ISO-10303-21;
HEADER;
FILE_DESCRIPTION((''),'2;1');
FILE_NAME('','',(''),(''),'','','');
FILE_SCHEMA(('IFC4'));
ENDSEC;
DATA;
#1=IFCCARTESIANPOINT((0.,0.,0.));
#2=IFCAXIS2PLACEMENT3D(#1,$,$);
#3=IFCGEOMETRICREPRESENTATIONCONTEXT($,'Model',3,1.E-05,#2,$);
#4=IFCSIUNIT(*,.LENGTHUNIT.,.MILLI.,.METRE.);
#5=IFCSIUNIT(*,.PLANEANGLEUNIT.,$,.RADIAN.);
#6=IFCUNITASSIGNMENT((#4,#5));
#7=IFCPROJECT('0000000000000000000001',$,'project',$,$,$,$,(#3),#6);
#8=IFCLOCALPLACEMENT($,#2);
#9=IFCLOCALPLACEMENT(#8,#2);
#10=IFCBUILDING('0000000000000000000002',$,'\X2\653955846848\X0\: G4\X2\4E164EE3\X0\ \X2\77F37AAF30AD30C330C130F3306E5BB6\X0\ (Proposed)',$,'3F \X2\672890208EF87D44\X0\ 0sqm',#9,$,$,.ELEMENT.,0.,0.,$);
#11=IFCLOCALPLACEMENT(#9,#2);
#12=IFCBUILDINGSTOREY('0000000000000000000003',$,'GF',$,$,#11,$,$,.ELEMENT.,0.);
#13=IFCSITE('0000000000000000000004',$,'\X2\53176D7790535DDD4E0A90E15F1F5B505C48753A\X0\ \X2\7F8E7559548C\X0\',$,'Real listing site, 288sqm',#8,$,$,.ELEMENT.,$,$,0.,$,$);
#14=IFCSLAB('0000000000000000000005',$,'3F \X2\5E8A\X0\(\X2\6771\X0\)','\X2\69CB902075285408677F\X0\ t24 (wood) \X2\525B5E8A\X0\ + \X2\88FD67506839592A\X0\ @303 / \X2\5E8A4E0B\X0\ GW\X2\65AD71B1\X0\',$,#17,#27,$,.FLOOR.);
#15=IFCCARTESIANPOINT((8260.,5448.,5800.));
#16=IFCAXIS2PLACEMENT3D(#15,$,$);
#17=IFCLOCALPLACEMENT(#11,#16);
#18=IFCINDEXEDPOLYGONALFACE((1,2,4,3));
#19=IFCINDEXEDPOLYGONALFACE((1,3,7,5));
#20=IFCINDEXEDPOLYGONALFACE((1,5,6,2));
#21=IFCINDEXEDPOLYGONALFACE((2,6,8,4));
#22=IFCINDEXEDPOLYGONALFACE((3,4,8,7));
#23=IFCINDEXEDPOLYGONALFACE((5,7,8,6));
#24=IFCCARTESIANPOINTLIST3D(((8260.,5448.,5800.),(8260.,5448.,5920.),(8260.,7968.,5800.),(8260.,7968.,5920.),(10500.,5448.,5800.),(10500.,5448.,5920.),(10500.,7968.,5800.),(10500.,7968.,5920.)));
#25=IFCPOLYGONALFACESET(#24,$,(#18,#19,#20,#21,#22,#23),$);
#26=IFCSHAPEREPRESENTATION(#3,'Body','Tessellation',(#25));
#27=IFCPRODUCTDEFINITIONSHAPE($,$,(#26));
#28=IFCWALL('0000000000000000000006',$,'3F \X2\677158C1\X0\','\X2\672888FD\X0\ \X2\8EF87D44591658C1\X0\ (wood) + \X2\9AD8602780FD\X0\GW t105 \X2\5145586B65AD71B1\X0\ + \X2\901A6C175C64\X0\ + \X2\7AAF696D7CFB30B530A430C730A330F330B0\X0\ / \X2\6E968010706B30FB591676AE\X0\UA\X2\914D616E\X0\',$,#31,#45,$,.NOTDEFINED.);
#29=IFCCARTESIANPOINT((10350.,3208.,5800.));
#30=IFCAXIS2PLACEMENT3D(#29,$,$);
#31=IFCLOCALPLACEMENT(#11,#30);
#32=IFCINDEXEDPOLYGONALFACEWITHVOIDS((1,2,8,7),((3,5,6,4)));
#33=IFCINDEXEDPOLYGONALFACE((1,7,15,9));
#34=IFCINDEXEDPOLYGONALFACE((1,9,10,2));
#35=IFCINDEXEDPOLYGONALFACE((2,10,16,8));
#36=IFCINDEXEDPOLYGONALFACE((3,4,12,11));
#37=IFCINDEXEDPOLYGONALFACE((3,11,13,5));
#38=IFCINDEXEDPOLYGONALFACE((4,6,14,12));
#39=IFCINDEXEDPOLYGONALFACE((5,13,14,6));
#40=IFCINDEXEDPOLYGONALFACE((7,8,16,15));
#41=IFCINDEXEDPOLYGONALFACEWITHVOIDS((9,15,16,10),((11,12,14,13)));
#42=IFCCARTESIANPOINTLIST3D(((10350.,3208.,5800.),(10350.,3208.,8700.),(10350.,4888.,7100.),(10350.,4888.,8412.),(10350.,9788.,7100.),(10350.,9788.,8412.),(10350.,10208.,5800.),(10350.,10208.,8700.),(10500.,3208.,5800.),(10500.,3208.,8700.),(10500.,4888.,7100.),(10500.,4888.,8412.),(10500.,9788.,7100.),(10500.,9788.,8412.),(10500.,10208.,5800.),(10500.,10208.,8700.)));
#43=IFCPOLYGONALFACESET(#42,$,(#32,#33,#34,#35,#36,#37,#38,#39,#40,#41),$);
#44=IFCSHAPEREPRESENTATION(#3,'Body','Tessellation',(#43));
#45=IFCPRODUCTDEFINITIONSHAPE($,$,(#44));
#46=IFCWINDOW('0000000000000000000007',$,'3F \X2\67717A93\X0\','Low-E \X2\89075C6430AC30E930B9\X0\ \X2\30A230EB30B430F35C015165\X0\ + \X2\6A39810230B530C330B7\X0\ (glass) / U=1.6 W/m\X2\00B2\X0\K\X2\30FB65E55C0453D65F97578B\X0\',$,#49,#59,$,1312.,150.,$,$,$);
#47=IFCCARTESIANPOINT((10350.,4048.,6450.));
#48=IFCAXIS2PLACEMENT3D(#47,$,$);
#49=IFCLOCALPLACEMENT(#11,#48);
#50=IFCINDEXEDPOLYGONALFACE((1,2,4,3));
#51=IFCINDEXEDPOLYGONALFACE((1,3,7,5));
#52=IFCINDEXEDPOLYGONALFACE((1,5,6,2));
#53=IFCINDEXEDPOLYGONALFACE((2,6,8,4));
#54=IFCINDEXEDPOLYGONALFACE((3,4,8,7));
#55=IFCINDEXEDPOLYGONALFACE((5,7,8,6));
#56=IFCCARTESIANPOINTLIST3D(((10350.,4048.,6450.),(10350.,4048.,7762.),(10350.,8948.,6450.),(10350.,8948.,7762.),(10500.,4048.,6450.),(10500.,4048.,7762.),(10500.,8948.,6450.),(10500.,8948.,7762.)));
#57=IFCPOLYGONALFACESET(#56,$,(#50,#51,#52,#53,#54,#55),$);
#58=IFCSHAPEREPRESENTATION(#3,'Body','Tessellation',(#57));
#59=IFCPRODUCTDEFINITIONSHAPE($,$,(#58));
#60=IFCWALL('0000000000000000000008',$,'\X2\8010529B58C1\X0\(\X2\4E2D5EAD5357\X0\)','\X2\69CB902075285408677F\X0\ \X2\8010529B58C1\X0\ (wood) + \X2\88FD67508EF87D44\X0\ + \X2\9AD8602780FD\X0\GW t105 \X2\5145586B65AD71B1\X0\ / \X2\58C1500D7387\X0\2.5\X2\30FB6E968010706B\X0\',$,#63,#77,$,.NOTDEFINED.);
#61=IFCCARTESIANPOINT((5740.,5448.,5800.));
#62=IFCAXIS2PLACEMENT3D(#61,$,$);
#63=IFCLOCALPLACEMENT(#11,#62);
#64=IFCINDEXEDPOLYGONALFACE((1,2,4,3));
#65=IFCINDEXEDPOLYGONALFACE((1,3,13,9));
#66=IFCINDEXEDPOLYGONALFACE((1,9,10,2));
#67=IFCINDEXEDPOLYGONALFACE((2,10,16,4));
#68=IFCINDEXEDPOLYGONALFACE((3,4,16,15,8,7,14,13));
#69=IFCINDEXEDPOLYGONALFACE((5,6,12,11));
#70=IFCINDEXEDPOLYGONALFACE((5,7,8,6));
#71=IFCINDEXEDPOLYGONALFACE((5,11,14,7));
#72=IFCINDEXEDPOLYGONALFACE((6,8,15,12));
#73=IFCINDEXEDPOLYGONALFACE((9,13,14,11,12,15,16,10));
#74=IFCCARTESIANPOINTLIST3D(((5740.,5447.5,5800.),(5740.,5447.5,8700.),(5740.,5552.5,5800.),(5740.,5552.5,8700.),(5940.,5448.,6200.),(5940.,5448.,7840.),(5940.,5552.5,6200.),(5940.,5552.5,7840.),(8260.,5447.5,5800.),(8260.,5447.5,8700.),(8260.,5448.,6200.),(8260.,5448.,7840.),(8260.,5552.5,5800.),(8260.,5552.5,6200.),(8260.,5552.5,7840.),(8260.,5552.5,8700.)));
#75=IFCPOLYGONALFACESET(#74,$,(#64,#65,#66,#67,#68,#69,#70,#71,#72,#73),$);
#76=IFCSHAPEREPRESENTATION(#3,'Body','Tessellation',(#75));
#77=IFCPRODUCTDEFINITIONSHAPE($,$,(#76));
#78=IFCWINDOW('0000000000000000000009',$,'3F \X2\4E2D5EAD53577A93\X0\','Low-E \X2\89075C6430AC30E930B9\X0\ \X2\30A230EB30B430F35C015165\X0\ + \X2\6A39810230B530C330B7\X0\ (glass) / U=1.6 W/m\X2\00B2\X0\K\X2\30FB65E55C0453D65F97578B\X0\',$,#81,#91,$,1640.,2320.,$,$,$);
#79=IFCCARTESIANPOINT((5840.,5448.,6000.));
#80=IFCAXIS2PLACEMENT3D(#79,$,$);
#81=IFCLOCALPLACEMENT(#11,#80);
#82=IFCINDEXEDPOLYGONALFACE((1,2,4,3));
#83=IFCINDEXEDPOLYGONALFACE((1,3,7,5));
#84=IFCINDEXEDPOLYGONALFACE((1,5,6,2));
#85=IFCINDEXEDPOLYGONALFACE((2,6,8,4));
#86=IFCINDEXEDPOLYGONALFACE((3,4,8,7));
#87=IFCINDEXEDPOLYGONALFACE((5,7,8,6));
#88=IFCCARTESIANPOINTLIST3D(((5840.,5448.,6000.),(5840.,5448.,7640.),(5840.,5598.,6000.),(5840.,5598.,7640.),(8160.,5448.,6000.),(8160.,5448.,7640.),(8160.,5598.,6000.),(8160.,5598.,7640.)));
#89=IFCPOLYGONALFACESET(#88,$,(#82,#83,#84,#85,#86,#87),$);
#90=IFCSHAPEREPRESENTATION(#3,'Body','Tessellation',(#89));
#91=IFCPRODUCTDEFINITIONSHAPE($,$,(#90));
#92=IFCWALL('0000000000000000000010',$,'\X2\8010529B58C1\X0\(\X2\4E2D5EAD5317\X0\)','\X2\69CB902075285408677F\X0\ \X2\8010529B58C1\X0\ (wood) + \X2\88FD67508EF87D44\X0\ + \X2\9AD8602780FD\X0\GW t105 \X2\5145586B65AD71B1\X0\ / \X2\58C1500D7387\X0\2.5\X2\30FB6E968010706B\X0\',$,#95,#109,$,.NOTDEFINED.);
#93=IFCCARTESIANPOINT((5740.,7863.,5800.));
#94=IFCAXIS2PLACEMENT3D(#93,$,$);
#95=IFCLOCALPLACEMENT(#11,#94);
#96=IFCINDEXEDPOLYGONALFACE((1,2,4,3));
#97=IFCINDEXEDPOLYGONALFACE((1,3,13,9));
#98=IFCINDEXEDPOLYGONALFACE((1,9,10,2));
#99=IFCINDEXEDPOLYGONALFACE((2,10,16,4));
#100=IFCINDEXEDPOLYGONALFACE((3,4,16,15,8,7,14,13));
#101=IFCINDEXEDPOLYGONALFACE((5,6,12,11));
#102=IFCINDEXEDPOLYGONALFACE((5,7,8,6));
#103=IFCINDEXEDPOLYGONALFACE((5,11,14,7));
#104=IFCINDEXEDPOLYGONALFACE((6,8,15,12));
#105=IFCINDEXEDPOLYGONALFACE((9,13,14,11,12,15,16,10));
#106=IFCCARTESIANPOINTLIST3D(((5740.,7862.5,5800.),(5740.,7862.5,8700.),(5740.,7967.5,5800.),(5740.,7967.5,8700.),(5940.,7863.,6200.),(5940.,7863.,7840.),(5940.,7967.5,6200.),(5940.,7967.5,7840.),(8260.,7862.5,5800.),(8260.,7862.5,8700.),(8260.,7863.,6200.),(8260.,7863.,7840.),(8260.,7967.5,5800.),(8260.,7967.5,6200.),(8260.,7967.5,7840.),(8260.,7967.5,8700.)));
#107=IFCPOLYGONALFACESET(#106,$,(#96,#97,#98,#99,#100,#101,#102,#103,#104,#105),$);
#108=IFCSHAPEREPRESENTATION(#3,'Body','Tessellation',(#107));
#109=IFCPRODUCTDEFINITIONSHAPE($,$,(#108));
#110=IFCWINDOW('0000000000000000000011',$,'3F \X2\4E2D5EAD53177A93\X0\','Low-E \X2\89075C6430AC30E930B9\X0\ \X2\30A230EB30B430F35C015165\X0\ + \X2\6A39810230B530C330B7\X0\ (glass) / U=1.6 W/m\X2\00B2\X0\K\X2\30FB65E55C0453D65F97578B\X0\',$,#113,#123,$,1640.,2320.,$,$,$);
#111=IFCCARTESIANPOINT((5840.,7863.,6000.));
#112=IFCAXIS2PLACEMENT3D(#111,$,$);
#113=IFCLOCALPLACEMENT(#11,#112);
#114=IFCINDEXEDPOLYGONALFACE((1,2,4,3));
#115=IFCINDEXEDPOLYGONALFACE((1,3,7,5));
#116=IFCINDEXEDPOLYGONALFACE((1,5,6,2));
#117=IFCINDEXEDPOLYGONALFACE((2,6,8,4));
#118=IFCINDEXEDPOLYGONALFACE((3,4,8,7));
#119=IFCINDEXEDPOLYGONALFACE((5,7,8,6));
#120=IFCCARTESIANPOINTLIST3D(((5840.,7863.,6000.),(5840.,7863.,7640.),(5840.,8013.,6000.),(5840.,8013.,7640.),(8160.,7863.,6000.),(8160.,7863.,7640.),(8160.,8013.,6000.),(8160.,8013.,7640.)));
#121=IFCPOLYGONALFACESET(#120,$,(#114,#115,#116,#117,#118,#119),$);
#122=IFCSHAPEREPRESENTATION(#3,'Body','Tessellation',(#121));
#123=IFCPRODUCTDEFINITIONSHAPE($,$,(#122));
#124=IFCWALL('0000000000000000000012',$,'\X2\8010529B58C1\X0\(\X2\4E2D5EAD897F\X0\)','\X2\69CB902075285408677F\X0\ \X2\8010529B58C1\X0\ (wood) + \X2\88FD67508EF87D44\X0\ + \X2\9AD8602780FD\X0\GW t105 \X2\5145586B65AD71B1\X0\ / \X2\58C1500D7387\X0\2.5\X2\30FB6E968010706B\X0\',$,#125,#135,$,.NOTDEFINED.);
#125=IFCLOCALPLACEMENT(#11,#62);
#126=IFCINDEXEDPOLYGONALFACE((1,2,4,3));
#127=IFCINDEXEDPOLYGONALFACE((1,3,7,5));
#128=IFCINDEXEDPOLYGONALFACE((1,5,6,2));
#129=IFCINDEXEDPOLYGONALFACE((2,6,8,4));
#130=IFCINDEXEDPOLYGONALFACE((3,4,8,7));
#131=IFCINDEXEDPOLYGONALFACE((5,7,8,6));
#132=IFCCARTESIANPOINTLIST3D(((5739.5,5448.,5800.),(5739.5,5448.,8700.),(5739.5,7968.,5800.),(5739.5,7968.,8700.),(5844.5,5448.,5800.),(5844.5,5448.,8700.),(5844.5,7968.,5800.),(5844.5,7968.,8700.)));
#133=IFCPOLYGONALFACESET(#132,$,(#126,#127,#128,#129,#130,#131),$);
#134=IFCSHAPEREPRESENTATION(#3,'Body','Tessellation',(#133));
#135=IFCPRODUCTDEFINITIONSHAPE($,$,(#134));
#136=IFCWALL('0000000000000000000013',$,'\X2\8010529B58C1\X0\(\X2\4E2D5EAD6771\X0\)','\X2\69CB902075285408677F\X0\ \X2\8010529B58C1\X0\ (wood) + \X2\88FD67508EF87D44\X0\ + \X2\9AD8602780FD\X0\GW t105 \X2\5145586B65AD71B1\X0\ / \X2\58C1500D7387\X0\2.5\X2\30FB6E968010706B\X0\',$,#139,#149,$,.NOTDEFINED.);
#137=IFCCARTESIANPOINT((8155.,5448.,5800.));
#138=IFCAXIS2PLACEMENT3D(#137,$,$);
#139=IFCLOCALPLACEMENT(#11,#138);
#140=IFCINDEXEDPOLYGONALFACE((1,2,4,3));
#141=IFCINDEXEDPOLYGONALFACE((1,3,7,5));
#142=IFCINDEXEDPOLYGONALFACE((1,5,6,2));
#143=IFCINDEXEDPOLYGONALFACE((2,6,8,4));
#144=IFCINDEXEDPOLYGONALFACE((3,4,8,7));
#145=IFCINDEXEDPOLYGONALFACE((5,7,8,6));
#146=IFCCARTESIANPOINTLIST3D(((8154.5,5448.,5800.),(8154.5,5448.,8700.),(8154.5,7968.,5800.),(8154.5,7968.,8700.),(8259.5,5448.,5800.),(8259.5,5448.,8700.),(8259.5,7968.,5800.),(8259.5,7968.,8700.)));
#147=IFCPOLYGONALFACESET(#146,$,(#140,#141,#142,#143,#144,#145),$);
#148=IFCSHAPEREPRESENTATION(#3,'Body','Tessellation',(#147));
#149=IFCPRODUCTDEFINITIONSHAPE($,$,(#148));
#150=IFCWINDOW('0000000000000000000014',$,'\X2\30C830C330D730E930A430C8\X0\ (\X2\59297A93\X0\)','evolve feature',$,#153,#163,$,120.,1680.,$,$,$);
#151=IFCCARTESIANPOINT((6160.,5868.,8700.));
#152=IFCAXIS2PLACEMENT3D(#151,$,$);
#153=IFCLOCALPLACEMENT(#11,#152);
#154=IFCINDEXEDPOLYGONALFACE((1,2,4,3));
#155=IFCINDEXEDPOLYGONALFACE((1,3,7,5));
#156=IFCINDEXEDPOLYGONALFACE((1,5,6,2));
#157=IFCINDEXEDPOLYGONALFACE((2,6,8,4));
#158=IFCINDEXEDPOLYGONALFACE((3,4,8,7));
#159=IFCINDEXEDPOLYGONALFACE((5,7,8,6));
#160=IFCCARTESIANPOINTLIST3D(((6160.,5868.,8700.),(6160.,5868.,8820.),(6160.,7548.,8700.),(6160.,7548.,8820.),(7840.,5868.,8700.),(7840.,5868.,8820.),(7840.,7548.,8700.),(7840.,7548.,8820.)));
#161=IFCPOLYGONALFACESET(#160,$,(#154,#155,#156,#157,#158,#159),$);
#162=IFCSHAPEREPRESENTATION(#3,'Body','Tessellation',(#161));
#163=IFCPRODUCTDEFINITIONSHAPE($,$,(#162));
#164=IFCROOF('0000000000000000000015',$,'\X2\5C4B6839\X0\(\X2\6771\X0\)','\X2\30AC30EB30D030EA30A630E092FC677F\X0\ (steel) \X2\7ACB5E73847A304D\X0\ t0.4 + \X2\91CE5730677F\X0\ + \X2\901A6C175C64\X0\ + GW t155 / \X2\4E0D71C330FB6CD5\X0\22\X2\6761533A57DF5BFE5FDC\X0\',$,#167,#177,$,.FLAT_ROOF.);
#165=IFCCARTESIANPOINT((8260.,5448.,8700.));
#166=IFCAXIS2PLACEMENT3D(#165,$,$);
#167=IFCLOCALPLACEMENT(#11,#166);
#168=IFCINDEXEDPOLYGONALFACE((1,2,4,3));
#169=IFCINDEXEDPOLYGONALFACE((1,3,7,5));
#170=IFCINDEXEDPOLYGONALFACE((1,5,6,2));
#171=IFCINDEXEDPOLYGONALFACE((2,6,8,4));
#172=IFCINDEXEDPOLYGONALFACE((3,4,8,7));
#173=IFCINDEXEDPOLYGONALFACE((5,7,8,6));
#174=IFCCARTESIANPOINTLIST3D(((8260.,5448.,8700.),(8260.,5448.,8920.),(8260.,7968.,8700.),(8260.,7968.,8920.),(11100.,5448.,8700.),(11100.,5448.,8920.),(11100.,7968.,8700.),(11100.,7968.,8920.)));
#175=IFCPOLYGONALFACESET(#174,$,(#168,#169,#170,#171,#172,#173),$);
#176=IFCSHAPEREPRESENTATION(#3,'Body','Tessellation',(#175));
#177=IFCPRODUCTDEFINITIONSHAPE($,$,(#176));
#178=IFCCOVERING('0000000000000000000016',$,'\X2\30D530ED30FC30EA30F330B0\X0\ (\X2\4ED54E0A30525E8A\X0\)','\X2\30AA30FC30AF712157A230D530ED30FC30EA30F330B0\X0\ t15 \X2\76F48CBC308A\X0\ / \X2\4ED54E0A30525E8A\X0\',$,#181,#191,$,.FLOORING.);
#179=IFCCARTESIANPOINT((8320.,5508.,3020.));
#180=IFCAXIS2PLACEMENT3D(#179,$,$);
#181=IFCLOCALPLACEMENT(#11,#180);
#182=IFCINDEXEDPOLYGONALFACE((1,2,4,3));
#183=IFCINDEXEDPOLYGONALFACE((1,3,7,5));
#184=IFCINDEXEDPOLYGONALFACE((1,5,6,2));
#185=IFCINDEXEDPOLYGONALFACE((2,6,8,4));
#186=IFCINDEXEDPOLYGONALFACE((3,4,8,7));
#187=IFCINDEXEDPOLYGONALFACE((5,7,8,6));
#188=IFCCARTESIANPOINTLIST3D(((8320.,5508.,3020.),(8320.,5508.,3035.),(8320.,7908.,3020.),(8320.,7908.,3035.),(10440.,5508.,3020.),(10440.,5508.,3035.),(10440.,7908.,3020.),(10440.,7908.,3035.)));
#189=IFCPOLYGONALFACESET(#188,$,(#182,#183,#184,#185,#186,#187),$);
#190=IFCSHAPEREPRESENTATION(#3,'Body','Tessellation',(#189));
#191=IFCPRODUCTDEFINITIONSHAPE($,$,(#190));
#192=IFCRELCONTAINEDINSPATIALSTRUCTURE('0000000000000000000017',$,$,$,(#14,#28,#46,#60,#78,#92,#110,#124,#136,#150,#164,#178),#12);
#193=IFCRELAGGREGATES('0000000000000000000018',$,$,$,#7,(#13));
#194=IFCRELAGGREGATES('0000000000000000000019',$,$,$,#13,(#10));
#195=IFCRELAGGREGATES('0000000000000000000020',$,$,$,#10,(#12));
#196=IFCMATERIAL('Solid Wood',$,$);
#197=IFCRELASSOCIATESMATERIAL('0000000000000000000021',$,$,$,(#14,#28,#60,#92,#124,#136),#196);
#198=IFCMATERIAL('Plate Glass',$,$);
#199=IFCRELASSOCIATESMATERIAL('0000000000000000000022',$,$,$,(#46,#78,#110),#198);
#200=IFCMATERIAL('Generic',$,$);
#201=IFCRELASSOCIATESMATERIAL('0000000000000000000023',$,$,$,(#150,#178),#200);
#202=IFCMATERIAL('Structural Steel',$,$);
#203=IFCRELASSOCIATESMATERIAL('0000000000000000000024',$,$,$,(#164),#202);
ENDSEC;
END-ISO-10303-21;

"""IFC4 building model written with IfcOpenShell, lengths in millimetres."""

from ifc_helpers import new_model, si_unit, frame, frame_2d, origin, place, context, project, spatial, rectangle, extrude, material, element, fill, save


model = new_model("IFC4")

# Units and contexts
model_context = context("Model", 3, precision=1e-05, world=origin())
ifc_project = project(units=[si_unit("LENGTHUNIT", "METRE", prefix="MILLI"), si_unit("PLANEANGLEUNIT", "RADIAN")], contexts=[model_context])

# Site, building, storey
site_placement = place(None, origin())
site = spatial("IfcSite", under=ifc_project, at=site_placement, Name="北海道川上郡弟子屈町 美留和", ObjectType="Real listing site, 288sqm", CompositionType="ELEMENT", RefElevation=0.0)
building_placement = place(site_placement, origin())
building = spatial("IfcBuilding", under=site, at=building_placement, Name="改善案: G4世代 石窯キッチンの家 (Proposed)", ObjectType="3F 木造軸組 0sqm", CompositionType="ELEMENT", ElevationOfRefHeight=0.0, ElevationOfTerrain=0.0)
storey_placement = place(building_placement, origin())
storey = spatial("IfcBuildingStorey", under=building, at=storey_placement, Name="GF", CompositionType="ELEMENT", Elevation=0.0)

# Slab
ifc_material_1 = material(Name="Solid Wood")
slab_placement = place(storey_placement, frame((8260.0, 5448.0, 5800.0)))
element("IfcSlab", 1, at=slab_placement, inside=storey, material=ifc_material_1, Name="3F 床(東)", Description="構造用合板 t24 (wood) 剛床 + 製材根太 @303 / 床下 GW断熱", PredefinedType="FLOOR", context=model_context, shape_type="SweptSolid", body=[
    extrude(rectangle(XDim=2240.0, YDim=2520.0, at=frame_2d((1120.0, 1260.0))), frame((8260.0, 5448.0, 5800.0)), (0.0, 0.0, 1.0), 120.0),
])

# Walls, openings, windows
wall_1_placement = place(storey_placement, frame((10350.0, 3208.0, 5800.0)))
wall_1 = element("IfcWall", 2, at=wall_1_placement, inside=storey, material=ifc_material_1, Name="3F 東壁", Description="木製 軸組外壁 (wood) + 高性能GW t105 充填断熱 + 通気層 + 窯業系サイディング / 準耐火・外皮UA配慮", PredefinedType="NOTDEFINED", context=model_context, shape_type="SweptSolid", body=[
    extrude(rectangle(XDim=150.0, YDim=7000.0, at=frame_2d((75.0, 3500.0))), frame((10350.0, 3208.0, 5800.0)), (0.0, 0.0, 1.0), 2900.0),
])
opening_1_placement = place(storey_placement, frame((10350.0, 4048.0, 6450.0)))
opening_1 = element("IfcOpeningElement", 3, at=opening_1_placement, cuts=wall_1, PredefinedType="NOTDEFINED", context=model_context, shape_type="SweptSolid", body=[
    extrude(rectangle(XDim=150.0, YDim=4900.0, at=frame_2d((75.0, 2450.0))), frame((10350.0, 4048.0, 6450.0)), (0.0, 0.0, 1.0), 1312.0),
])
ifc_material_2 = material(Name="Plate Glass")
window_1_placement = place(storey_placement, frame((10350.0, 4048.0, 6450.0)))
window_1 = element("IfcWindow", 4, at=window_1_placement, inside=storey, material=ifc_material_2, Name="3F 東窓", Description="Low-E 複層ガラス アルゴン封入 + 樹脂サッシ (glass) / U=1.6 W/m²K・日射取得型", OverallHeight=1312.0, OverallWidth=150.0, context=model_context, shape_type="SweptSolid", body=[
    extrude(rectangle(XDim=150.0, YDim=4900.0, at=frame_2d((75.0, 2450.0))), frame((10350.0, 4048.0, 6450.0)), (0.0, 0.0, 1.0), 1312.0),
])
fill(opening_1, window_1)
wall_2_placement = place(storey_placement, frame((5740.0, 5448.0, 5800.0)))
wall_2 = element("IfcWall", 5, at=wall_2_placement, inside=storey, material=ifc_material_1, Name="耐力壁(中庭南)", Description="構造用合板 耐力壁 (wood) + 製材軸組 + 高性能GW t105 充填断熱 / 壁倍率2.5・準耐火", PredefinedType="NOTDEFINED", context=model_context, shape_type="SweptSolid", body=[
    extrude(rectangle(XDim=2520.0, YDim=105.0, at=frame_2d((1260.0, 52.0))), frame((5740.0, 5448.0, 5800.0)), (0.0, 0.0, 1.0), 2900.0),
])
opening_2_placement = place(storey_placement, frame((5840.0, 5448.0, 6000.0)))
opening_2 = element("IfcOpeningElement", 6, at=opening_2_placement, cuts=wall_2, PredefinedType="NOTDEFINED", context=model_context, shape_type="SweptSolid", body=[
    extrude(rectangle(XDim=2320.0, YDim=150.0, at=frame_2d((1160.0, 75.0))), frame((5840.0, 5448.0, 6000.0)), (0.0, 0.0, 1.0), 1640.0),
])
window_2_placement = place(storey_placement, frame((5840.0, 5448.0, 6000.0)))
window_2 = element("IfcWindow", 7, at=window_2_placement, inside=storey, material=ifc_material_2, Name="3F 中庭南窓", Description="Low-E 複層ガラス アルゴン封入 + 樹脂サッシ (glass) / U=1.6 W/m²K・日射取得型", OverallHeight=1640.0, OverallWidth=2320.0, context=model_context, shape_type="SweptSolid", body=[
    extrude(rectangle(XDim=2320.0, YDim=150.0, at=frame_2d((1160.0, 75.0))), frame((5840.0, 5448.0, 6000.0)), (0.0, 0.0, 1.0), 1640.0),
])
fill(opening_2, window_2)
wall_3_placement = place(storey_placement, frame((5740.0, 7863.0, 5800.0)))
wall_3 = element("IfcWall", 8, at=wall_3_placement, inside=storey, material=ifc_material_1, Name="耐力壁(中庭北)", Description="構造用合板 耐力壁 (wood) + 製材軸組 + 高性能GW t105 充填断熱 / 壁倍率2.5・準耐火", PredefinedType="NOTDEFINED", context=model_context, shape_type="SweptSolid", body=[
    extrude(rectangle(XDim=2520.0, YDim=105.0, at=frame_2d((1260.0, 52.0))), frame((5740.0, 7863.0, 5800.0)), (0.0, 0.0, 1.0), 2900.0),
])
opening_3_placement = place(storey_placement, frame((5840.0, 7863.0, 6000.0)))
opening_3 = element("IfcOpeningElement", 9, at=opening_3_placement, cuts=wall_3, PredefinedType="NOTDEFINED", context=model_context, shape_type="SweptSolid", body=[
    extrude(rectangle(XDim=2320.0, YDim=150.0, at=frame_2d((1160.0, 75.0))), frame((5840.0, 7863.0, 6000.0)), (0.0, 0.0, 1.0), 1640.0),
])
window_3_placement = place(storey_placement, frame((5840.0, 7863.0, 6000.0)))
window_3 = element("IfcWindow", 10, at=window_3_placement, inside=storey, material=ifc_material_2, Name="3F 中庭北窓", Description="Low-E 複層ガラス アルゴン封入 + 樹脂サッシ (glass) / U=1.6 W/m²K・日射取得型", OverallHeight=1640.0, OverallWidth=2320.0, context=model_context, shape_type="SweptSolid", body=[
    extrude(rectangle(XDim=2320.0, YDim=150.0, at=frame_2d((1160.0, 75.0))), frame((5840.0, 7863.0, 6000.0)), (0.0, 0.0, 1.0), 1640.0),
])
fill(opening_3, window_3)

# Walls
wall_4_placement = place(storey_placement, frame((5740.0, 5448.0, 5800.0)))
element("IfcWall", 11, at=wall_4_placement, inside=storey, material=ifc_material_1, Name="耐力壁(中庭西)", Description="構造用合板 耐力壁 (wood) + 製材軸組 + 高性能GW t105 充填断熱 / 壁倍率2.5・準耐火", PredefinedType="NOTDEFINED", context=model_context, shape_type="SweptSolid", body=[
    extrude(rectangle(XDim=105.0, YDim=2520.0, at=frame_2d((52.0, 1260.0))), frame((5740.0, 5448.0, 5800.0)), (0.0, 0.0, 1.0), 2900.0),
])
wall_5_placement = place(storey_placement, frame((8155.0, 5448.0, 5800.0)))
element("IfcWall", 12, at=wall_5_placement, inside=storey, material=ifc_material_1, Name="耐力壁(中庭東)", Description="構造用合板 耐力壁 (wood) + 製材軸組 + 高性能GW t105 充填断熱 / 壁倍率2.5・準耐火", PredefinedType="NOTDEFINED", context=model_context, shape_type="SweptSolid", body=[
    extrude(rectangle(XDim=105.0, YDim=2520.0, at=frame_2d((52.0, 1260.0))), frame((8155.0, 5448.0, 5800.0)), (0.0, 0.0, 1.0), 2900.0),
])

# Window
ifc_material_3 = material(Name="Generic")
window_4_placement = place(storey_placement, frame((6160.0, 5868.0, 8700.0)))
element("IfcWindow", 13, at=window_4_placement, inside=storey, material=ifc_material_3, Name="トップライト (天窓)", Description="evolve feature", OverallHeight=120.0, OverallWidth=1680.0, context=model_context, shape_type="SweptSolid", body=[
    extrude(rectangle(XDim=1680.0, YDim=1680.0, at=frame_2d((840.0, 840.0))), frame((6160.0, 5868.0, 8700.0)), (0.0, 0.0, 1.0), 120.0),
])

# Roof
ifc_material_4 = material(Name="Structural Steel")
for number, where, name in (
    (14, (8260.0, 5448.0, 8700.0), "屋根(東)"),
):
    element("IfcRoof", number, at=place(storey_placement, frame(where)), inside=storey, material=ifc_material_4, Name=name, Description="ガルバリウム鋼板 (steel) 立平葺き t0.4 + 野地板 + 通気層 + GW t155 / 不燃・法22条区域対応", PredefinedType="FLAT_ROOF", context=model_context, shape_type="SweptSolid", body=[
        extrude(rectangle(XDim=2840.0, YDim=2520.0, at=frame_2d((1420.0, 1260.0))), frame((8260.0, 5448.0, 8700.0)), (0.0, 0.0, 1.0), 220.0),
    ])

# Covering
covering_1_placement = place(storey_placement, frame((8320.0, 5508.0, 3020.0)))
element("IfcCovering", 15, at=covering_1_placement, inside=storey, material=ifc_material_3, Name="フローリング (仕上げ床)", Description="オーク無垢フローリング t15 直貼り / 仕上げ床", PredefinedType="FLOORING", context=model_context, shape_type="SweptSolid", body=[
    extrude(rectangle(XDim=2120.0, YDim=2400.0, at=frame_2d((1060.0, 1200.0))), frame((8320.0, 5508.0, 3020.0)), (0.0, 0.0, 1.0), 15.0),
])

save(model, "model.ifc")
